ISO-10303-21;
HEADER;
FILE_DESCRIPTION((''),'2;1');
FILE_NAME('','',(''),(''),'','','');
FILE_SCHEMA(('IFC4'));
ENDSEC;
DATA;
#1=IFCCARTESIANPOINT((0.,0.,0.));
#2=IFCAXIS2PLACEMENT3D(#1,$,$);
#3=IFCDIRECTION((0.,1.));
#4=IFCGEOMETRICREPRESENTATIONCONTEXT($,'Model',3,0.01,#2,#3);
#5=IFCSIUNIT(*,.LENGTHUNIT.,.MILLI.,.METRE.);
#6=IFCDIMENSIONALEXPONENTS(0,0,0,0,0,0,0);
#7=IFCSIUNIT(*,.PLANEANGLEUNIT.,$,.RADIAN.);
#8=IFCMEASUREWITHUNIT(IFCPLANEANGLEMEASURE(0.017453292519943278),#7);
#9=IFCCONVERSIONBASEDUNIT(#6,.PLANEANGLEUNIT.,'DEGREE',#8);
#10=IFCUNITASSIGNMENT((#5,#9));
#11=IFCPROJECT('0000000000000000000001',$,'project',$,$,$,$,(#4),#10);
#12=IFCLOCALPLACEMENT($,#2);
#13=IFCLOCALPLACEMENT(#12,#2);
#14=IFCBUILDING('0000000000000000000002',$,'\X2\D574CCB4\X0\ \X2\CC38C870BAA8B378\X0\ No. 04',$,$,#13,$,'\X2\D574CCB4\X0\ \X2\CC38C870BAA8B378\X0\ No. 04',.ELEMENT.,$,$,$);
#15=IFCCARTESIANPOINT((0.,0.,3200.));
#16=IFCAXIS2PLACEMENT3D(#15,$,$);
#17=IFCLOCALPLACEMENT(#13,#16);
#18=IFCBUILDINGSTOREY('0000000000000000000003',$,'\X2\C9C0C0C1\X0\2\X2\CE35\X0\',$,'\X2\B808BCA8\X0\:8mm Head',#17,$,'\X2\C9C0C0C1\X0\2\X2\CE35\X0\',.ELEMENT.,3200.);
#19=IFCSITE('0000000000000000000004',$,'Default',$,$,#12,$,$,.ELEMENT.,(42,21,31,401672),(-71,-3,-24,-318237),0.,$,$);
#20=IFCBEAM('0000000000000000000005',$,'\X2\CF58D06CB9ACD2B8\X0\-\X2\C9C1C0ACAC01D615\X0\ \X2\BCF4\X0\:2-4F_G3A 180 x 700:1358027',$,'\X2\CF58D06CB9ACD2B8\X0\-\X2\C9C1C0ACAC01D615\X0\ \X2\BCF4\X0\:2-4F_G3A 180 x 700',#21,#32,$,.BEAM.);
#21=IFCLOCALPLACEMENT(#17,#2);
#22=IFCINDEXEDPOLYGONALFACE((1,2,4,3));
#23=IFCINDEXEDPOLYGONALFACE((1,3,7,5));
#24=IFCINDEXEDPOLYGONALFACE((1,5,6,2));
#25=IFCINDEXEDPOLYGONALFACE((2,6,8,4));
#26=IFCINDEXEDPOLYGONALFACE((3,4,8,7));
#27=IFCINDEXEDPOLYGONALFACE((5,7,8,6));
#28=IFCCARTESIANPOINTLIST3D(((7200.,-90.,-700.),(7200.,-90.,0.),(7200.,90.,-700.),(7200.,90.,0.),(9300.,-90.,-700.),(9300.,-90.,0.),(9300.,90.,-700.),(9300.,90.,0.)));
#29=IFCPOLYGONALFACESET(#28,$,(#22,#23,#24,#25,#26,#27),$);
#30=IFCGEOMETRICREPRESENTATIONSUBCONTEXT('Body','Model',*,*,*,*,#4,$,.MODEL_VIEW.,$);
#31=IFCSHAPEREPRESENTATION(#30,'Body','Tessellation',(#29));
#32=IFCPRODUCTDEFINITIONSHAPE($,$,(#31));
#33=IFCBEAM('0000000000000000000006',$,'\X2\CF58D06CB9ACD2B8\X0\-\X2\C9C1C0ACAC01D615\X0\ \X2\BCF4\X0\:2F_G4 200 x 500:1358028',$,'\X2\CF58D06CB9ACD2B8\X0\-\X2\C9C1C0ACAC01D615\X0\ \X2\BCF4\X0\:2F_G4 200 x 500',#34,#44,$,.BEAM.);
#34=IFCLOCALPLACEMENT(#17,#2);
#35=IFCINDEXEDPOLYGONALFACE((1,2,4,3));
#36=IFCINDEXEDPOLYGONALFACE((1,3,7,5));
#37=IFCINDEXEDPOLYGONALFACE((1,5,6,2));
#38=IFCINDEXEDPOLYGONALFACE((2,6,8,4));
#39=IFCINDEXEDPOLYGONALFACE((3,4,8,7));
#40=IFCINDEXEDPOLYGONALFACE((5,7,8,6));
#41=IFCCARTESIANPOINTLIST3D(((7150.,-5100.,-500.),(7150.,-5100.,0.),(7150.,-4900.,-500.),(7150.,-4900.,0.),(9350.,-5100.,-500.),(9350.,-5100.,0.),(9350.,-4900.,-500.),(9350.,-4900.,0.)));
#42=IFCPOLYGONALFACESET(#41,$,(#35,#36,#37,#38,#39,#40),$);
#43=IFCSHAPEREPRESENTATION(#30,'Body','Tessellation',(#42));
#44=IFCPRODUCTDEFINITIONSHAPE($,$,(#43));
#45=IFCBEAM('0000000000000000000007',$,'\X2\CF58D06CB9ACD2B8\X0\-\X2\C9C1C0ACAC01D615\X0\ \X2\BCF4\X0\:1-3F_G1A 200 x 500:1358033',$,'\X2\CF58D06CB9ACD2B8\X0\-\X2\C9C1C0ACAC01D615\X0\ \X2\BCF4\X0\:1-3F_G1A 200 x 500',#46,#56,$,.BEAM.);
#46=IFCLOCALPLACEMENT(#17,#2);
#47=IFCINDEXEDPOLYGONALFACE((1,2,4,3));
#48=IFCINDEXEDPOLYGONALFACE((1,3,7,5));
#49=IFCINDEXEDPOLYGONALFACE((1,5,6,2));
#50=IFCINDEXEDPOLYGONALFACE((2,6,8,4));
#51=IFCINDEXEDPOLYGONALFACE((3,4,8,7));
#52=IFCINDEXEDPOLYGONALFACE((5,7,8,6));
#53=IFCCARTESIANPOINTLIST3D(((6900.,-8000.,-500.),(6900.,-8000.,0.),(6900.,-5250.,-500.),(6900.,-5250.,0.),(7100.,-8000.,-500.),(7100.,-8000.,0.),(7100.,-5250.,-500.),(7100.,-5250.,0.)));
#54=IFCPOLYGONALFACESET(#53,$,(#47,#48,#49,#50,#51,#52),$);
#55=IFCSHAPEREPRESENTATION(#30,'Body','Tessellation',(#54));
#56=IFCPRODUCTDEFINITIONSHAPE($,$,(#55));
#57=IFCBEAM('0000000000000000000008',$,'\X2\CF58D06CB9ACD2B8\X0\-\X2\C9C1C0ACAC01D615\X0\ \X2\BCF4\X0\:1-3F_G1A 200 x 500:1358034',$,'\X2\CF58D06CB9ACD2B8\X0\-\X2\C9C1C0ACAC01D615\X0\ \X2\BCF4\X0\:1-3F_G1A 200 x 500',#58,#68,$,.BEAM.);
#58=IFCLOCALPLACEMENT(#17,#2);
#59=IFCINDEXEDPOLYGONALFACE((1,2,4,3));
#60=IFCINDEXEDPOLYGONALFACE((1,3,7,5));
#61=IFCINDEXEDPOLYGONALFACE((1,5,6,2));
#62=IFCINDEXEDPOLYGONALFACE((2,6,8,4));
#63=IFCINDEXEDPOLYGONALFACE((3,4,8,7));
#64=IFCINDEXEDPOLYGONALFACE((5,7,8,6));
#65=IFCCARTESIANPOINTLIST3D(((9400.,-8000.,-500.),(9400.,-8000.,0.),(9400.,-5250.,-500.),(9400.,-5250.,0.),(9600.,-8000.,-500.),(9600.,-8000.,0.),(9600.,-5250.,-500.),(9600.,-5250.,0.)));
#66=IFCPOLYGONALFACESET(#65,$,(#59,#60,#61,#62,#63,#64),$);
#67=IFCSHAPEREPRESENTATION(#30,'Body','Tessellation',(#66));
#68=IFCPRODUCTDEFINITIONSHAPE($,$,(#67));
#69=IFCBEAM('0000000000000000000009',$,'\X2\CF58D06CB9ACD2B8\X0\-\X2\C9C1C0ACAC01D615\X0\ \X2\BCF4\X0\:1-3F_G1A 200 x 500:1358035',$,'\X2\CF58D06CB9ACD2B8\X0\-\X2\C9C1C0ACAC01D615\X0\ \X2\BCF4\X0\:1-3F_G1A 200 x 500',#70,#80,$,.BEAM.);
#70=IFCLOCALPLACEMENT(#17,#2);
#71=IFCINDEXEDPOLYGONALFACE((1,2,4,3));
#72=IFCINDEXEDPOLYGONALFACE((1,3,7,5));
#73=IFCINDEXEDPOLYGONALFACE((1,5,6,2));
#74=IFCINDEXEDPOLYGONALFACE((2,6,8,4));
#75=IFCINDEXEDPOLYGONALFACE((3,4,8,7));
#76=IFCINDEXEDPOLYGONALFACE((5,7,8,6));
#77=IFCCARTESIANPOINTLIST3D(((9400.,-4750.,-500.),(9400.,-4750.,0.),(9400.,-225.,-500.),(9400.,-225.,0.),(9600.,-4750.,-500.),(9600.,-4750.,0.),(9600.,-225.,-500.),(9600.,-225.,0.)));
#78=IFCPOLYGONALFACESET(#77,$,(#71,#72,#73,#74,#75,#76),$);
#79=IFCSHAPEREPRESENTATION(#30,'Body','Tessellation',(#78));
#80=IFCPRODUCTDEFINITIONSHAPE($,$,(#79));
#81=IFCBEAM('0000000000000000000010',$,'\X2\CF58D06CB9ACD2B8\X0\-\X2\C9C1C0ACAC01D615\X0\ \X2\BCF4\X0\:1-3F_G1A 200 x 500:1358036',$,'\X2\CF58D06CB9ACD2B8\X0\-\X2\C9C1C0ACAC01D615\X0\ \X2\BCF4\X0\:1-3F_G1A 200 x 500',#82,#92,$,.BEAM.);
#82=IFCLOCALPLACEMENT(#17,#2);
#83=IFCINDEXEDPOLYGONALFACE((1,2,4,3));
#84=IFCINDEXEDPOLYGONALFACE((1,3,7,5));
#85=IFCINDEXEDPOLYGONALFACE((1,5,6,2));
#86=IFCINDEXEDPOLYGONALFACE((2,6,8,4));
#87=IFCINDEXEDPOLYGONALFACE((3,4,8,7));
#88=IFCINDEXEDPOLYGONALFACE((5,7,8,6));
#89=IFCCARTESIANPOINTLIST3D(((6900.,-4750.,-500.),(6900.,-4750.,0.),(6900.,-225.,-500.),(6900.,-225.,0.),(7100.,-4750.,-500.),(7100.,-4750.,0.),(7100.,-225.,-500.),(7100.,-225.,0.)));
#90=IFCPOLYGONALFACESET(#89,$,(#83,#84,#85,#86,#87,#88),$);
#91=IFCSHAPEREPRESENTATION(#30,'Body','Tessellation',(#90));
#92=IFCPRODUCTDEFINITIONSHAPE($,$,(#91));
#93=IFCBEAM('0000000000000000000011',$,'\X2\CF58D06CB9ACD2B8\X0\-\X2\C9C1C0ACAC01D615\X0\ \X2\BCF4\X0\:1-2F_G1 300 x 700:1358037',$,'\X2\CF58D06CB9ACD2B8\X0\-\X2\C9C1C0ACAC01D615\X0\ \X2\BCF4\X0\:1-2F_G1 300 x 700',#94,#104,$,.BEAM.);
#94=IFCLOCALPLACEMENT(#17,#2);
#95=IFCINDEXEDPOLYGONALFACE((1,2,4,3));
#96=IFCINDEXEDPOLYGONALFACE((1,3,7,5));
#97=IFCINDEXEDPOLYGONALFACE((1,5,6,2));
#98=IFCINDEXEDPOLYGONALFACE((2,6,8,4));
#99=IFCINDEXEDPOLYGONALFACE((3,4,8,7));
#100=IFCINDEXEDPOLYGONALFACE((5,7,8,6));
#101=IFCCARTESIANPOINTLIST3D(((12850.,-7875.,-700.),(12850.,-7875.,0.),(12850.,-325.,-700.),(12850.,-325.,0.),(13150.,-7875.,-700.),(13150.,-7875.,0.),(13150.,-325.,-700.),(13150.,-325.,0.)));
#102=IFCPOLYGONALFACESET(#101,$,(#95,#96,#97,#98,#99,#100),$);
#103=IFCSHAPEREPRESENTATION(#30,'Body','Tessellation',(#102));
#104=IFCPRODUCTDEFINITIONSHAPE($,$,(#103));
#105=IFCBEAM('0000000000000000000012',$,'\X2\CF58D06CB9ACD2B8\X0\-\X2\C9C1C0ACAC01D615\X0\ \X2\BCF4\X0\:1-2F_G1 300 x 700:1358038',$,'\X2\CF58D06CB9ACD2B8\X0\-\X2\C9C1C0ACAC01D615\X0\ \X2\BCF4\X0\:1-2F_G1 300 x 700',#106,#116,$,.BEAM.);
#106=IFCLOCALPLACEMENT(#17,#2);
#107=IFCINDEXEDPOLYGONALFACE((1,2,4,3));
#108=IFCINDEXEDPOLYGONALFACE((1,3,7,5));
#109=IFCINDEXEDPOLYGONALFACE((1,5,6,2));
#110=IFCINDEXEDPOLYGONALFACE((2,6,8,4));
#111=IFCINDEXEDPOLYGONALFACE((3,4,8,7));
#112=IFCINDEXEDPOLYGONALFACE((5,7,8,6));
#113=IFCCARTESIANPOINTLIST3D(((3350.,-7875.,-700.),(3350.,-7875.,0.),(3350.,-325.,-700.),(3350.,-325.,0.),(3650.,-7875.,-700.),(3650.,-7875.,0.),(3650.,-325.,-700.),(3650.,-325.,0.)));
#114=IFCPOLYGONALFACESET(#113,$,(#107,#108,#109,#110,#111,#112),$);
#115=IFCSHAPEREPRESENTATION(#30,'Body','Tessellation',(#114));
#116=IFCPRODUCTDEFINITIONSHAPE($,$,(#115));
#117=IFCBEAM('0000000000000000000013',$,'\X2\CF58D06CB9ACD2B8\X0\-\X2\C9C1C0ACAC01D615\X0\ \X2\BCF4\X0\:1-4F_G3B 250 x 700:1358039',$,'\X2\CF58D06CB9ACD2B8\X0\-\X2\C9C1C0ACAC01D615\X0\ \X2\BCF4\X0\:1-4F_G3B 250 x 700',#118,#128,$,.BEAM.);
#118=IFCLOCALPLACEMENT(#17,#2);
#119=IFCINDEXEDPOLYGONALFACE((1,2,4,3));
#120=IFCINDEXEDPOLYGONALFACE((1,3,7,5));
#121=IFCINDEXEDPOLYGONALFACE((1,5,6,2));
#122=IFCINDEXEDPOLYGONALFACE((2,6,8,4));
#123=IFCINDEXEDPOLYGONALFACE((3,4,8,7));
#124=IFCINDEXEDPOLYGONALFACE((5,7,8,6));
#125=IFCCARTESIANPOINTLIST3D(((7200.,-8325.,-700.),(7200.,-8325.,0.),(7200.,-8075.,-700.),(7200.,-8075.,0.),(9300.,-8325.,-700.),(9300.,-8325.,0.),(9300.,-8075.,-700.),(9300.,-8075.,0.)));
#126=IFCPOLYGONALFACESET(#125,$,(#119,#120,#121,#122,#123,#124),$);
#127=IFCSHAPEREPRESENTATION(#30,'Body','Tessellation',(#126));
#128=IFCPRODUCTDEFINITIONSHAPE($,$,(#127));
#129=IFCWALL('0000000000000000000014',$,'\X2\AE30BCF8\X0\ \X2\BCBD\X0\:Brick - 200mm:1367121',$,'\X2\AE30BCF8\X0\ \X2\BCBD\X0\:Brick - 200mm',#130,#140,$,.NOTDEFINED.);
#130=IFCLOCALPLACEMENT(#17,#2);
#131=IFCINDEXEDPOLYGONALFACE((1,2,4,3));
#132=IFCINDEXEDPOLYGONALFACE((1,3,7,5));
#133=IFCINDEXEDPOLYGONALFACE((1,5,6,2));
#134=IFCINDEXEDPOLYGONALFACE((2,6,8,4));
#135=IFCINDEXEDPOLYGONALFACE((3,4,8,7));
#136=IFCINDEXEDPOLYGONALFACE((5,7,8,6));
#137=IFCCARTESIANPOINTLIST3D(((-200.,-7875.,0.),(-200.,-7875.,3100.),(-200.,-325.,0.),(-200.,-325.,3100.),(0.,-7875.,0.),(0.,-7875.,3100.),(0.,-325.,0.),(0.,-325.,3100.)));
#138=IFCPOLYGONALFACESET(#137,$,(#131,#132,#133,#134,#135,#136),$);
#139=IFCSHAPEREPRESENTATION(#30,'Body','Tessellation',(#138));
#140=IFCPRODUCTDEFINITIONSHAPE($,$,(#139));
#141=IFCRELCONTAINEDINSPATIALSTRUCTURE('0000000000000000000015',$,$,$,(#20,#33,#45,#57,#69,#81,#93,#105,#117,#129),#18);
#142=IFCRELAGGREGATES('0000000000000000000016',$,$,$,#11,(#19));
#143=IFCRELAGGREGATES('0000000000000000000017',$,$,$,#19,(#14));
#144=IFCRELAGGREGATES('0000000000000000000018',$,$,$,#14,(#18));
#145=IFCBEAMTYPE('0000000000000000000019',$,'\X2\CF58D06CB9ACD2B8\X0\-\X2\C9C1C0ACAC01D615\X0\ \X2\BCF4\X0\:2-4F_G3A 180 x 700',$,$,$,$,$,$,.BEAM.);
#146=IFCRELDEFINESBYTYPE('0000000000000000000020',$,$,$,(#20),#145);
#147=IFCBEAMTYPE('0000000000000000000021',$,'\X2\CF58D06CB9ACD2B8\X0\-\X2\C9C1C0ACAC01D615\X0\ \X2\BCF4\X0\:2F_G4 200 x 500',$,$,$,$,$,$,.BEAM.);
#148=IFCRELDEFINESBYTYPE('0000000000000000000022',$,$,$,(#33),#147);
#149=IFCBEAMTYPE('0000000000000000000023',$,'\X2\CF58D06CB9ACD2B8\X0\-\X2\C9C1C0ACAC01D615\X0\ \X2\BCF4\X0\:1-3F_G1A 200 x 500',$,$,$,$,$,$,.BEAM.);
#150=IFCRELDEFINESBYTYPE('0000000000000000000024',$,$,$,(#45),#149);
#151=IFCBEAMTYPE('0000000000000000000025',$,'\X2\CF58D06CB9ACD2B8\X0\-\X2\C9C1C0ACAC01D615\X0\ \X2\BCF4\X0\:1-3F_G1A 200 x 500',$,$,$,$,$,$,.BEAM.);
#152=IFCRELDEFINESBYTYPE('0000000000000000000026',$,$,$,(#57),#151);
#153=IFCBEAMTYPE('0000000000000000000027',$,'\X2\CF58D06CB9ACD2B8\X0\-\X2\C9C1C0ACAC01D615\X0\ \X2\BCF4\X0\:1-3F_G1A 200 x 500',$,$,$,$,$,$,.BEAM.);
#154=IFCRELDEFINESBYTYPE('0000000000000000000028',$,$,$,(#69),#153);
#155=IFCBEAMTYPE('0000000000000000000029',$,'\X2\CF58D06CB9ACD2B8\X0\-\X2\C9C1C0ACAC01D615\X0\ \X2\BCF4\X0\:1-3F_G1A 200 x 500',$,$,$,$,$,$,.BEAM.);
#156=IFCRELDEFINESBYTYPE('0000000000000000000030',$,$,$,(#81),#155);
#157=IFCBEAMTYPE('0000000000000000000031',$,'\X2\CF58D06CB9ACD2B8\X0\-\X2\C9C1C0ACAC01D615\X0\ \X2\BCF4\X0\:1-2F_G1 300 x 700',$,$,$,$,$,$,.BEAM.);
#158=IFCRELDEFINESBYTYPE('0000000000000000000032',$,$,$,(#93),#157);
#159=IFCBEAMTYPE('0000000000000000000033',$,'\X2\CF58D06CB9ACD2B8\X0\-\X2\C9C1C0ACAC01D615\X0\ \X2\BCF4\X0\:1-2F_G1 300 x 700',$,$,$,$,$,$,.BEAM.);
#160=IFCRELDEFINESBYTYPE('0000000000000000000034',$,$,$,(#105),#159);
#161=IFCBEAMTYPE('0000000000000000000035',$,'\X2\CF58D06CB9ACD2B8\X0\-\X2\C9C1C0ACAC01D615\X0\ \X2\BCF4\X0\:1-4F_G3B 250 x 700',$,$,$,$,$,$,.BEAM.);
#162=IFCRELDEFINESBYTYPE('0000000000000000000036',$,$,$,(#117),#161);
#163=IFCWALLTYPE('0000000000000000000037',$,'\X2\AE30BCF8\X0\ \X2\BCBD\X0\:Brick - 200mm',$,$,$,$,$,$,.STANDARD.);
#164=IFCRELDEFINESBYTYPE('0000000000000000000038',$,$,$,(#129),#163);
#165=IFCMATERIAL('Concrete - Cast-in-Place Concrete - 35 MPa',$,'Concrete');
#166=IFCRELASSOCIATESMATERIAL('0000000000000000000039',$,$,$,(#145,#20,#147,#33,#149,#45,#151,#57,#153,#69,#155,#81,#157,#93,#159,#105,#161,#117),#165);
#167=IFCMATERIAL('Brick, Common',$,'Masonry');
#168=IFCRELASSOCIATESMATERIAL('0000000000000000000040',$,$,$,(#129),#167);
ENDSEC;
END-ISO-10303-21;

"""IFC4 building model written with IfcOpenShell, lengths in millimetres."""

from ifc_helpers import new_model, entity, si_unit, converted_unit, direction, frame, origin, place, context, subcontext, project, spatial, indexed_curve, outline, extrude, source, transform, mapped, material, type_object, type_shapes, element, save


model = new_model("IFC4")

# Units and contexts
model_context = context("Model", 3, precision=0.01, world=origin(), true_north=direction((0.0, 1.0)))
body_context = subcontext(model_context, "Body", "Model", "MODEL_VIEW")
ifc_project = project(units=[si_unit("LENGTHUNIT", "METRE", prefix="MILLI"), converted_unit("PLANEANGLEUNIT", "DEGREE", entity("IfcPlaneAngleMeasure", 0.017453292519943278), si_unit("PLANEANGLEUNIT", "RADIAN"), dimensions=[0, 0, 0, 0, 0, 0, 0])], contexts=[model_context])

# Site, building, storey
site_placement = place(None, origin())
site = spatial("IfcSite", under=ifc_project, at=site_placement, Name="Default", CompositionType="ELEMENT", RefLatitude=(42, 21, 31, 401672), RefLongitude=(-71, -3, -24, -318237), RefElevation=0.0)
building_placement = place(site_placement, origin())
building = spatial("IfcBuilding", under=site, at=building_placement, Name="해체 참조모델 No. 04", LongName="해체 참조모델 No. 04", CompositionType="ELEMENT")
storey_placement = place(building_placement, frame((0.0, 0.0, 3200.0)))
storey = spatial("IfcBuildingStorey", under=building, at=storey_placement, Name="지상2층", ObjectType="레벨:8mm Head", LongName="지상2층", CompositionType="ELEMENT", Elevation=3200.0)

# Beams
ifc_material_1 = material(Name="Concrete - Cast-in-Place Concrete - 35 MPa", Category="Concrete")
beam_type_1 = type_object("IfcBeamType", Name="콘크리트-직사각형 보:2-4F_G3A 180 x 700", PredefinedType="BEAM", material=ifc_material_1)
shared_shape_1 = source(origin(), body_context, "Body", "SweptSolid", [
    extrude(outline(indexed_curve([(-350.0, -90.0), (350.0, -90.0), (350.0, 90.0), (-350.0, 90.0), (-350.0, -90.0)], self_intersect=False)), frame((7200.0, 0.0, 2850.0), z_axis=(1.0, 0.0, 0.0), x_axis=(0.0, 0.0, -1.0)), (0.0, 0.0, 1.0), 2100.0),
])
type_shapes(beam_type_1, [shared_shape_1])
beam_1_placement = place(storey_placement, frame((0.0, 0.0, -3200.0)))
element("IfcBeam", 1, at=beam_1_placement, inside=storey, type_object=beam_type_1, material=ifc_material_1, Name="콘크리트-직사각형 보:2-4F_G3A 180 x 700:1358027", ObjectType="콘크리트-직사각형 보:2-4F_G3A 180 x 700", PredefinedType="BEAM", context=body_context, shape_type="MappedRepresentation", body=[
    mapped(shared_shape_1, transform((0.0, 0.0, 0.0), scale=1.0)),
])
beam_type_2 = type_object("IfcBeamType", Name="콘크리트-직사각형 보:2F_G4 200 x 500", PredefinedType="BEAM", material=ifc_material_1)
shared_shape_2 = source(origin(), body_context, "Body", "SweptSolid", [
    extrude(outline(indexed_curve([(-250.0, -100.0), (250.0, -100.0), (250.0, 100.0), (-250.0, 100.0), (-250.0, -100.0)], self_intersect=False)), frame((7150.0, -5000.0, 2950.0), z_axis=(1.0, 0.0, 0.0), x_axis=(0.0, 0.0, -1.0)), (0.0, 0.0, 1.0), 2200.0),
])
type_shapes(beam_type_2, [shared_shape_2])
beam_2_placement = place(storey_placement, frame((0.0, 0.0, -3200.0)))
element("IfcBeam", 2, at=beam_2_placement, inside=storey, type_object=beam_type_2, material=ifc_material_1, Name="콘크리트-직사각형 보:2F_G4 200 x 500:1358028", ObjectType="콘크리트-직사각형 보:2F_G4 200 x 500", PredefinedType="BEAM", context=body_context, shape_type="MappedRepresentation", body=[
    mapped(shared_shape_2, transform((0.0, 0.0, 0.0), scale=1.0)),
])
beam_type_3 = type_object("IfcBeamType", Name="콘크리트-직사각형 보:1-3F_G1A 200 x 500", PredefinedType="BEAM", material=ifc_material_1)
shared_shape_3 = source(origin(), body_context, "Body", "SweptSolid", [
    extrude(outline(indexed_curve([(-100.0, -250.0), (100.0, -250.0), (100.0, 250.0), (-100.0, 250.0), (-100.0, -250.0)], self_intersect=False)), frame((7000.0, -5250.0, 2950.0), z_axis=(0.0, -1.0, 0.0), x_axis=(-1.0, 0.0, 0.0)), (0.0, 0.0, 1.0), 2750.0),
])
type_shapes(beam_type_3, [shared_shape_3])
beam_3_placement = place(storey_placement, frame((0.0, 0.0, -3200.0)))
element("IfcBeam", 3, at=beam_3_placement, inside=storey, type_object=beam_type_3, material=ifc_material_1, Name="콘크리트-직사각형 보:1-3F_G1A 200 x 500:1358033", ObjectType="콘크리트-직사각형 보:1-3F_G1A 200 x 500", PredefinedType="BEAM", context=body_context, shape_type="MappedRepresentation", body=[
    mapped(shared_shape_3, transform((0.0, 0.0, 0.0), scale=1.0)),
])
beam_type_4 = type_object("IfcBeamType", Name="콘크리트-직사각형 보:1-3F_G1A 200 x 500", PredefinedType="BEAM", material=ifc_material_1)
shared_shape_4 = source(origin(), body_context, "Body", "SweptSolid", [
    extrude(outline(indexed_curve([(-100.0, -250.0), (100.0, -250.0), (100.0, 250.0), (-100.0, 250.0), (-100.0, -250.0)], self_intersect=False)), frame((9500.0, -5250.0, 2950.0), z_axis=(0.0, -1.0, 0.0), x_axis=(-1.0, 0.0, 0.0)), (0.0, 0.0, 1.0), 2750.0),
])
type_shapes(beam_type_4, [shared_shape_4])
beam_4_placement = place(storey_placement, frame((0.0, 0.0, -3200.0)))
element("IfcBeam", 4, at=beam_4_placement, inside=storey, type_object=beam_type_4, material=ifc_material_1, Name="콘크리트-직사각형 보:1-3F_G1A 200 x 500:1358034", ObjectType="콘크리트-직사각형 보:1-3F_G1A 200 x 500", PredefinedType="BEAM", context=body_context, shape_type="MappedRepresentation", body=[
    mapped(shared_shape_4, transform((0.0, 0.0, 0.0), scale=1.0)),
])
beam_type_5 = type_object("IfcBeamType", Name="콘크리트-직사각형 보:1-3F_G1A 200 x 500", PredefinedType="BEAM", material=ifc_material_1)
shared_shape_5 = source(origin(), body_context, "Body", "SweptSolid", [
    extrude(outline(indexed_curve([(-100.0, -250.0), (100.0, -250.0), (100.0, 250.0), (-100.0, 250.0), (-100.0, -250.0)], self_intersect=False)), frame((9500.0, -225.0, 2950.0), z_axis=(0.0, -1.0, 0.0), x_axis=(-1.0, 0.0, 0.0)), (0.0, 0.0, 1.0), 4525.0),
])
type_shapes(beam_type_5, [shared_shape_5])
beam_5_placement = place(storey_placement, frame((0.0, 0.0, -3200.0)))
element("IfcBeam", 5, at=beam_5_placement, inside=storey, type_object=beam_type_5, material=ifc_material_1, Name="콘크리트-직사각형 보:1-3F_G1A 200 x 500:1358035", ObjectType="콘크리트-직사각형 보:1-3F_G1A 200 x 500", PredefinedType="BEAM", context=body_context, shape_type="MappedRepresentation", body=[
    mapped(shared_shape_5, transform((0.0, 0.0, 0.0), scale=1.0)),
])
beam_type_6 = type_object("IfcBeamType", Name="콘크리트-직사각형 보:1-3F_G1A 200 x 500", PredefinedType="BEAM", material=ifc_material_1)
shared_shape_6 = source(origin(), body_context, "Body", "SweptSolid", [
    extrude(outline(indexed_curve([(-100.0, -250.0), (100.0, -250.0), (100.0, 250.0), (-100.0, 250.0), (-100.0, -250.0)], self_intersect=False)), frame((7000.0, -225.0, 2950.0), z_axis=(0.0, -1.0, 0.0), x_axis=(-1.0, 0.0, 0.0)), (0.0, 0.0, 1.0), 4525.0),
])
type_shapes(beam_type_6, [shared_shape_6])
beam_6_placement = place(storey_placement, frame((0.0, 0.0, -3200.0)))
element("IfcBeam", 6, at=beam_6_placement, inside=storey, type_object=beam_type_6, material=ifc_material_1, Name="콘크리트-직사각형 보:1-3F_G1A 200 x 500:1358036", ObjectType="콘크리트-직사각형 보:1-3F_G1A 200 x 500", PredefinedType="BEAM", context=body_context, shape_type="MappedRepresentation", body=[
    mapped(shared_shape_6, transform((0.0, 0.0, 0.0), scale=1.0)),
])
beam_type_7 = type_object("IfcBeamType", Name="콘크리트-직사각형 보:1-2F_G1 300 x 700", PredefinedType="BEAM", material=ifc_material_1)
shared_shape_7 = source(origin(), body_context, "Body", "SweptSolid", [
    extrude(outline(indexed_curve([(-150.0, -350.0), (150.0, -350.0), (150.0, 350.0), (-150.0, 350.0), (-150.0, -350.0)], self_intersect=False)), frame((13000.0, -325.0, 2850.0), z_axis=(0.0, -1.0, 0.0), x_axis=(-1.0, 0.0, 0.0)), (0.0, 0.0, 1.0), 7550.0),
])
type_shapes(beam_type_7, [shared_shape_7])
beam_7_placement = place(storey_placement, frame((0.0, 0.0, -3200.0)))
element("IfcBeam", 7, at=beam_7_placement, inside=storey, type_object=beam_type_7, material=ifc_material_1, Name="콘크리트-직사각형 보:1-2F_G1 300 x 700:1358037", ObjectType="콘크리트-직사각형 보:1-2F_G1 300 x 700", PredefinedType="BEAM", context=body_context, shape_type="MappedRepresentation", body=[
    mapped(shared_shape_7, transform((0.0, 0.0, 0.0), scale=1.0)),
])
beam_type_8 = type_object("IfcBeamType", Name="콘크리트-직사각형 보:1-2F_G1 300 x 700", PredefinedType="BEAM", material=ifc_material_1)
shared_shape_8 = source(origin(), body_context, "Body", "SweptSolid", [
    extrude(outline(indexed_curve([(-150.0, -350.0), (150.0, -350.0), (150.0, 350.0), (-150.0, 350.0), (-150.0, -350.0)], self_intersect=False)), frame((3500.0, -325.0, 2850.0), z_axis=(0.0, -1.0, 0.0), x_axis=(-1.0, 0.0, 0.0)), (0.0, 0.0, 1.0), 7550.0),
])
type_shapes(beam_type_8, [shared_shape_8])
beam_8_placement = place(storey_placement, frame((0.0, 0.0, -3200.0)))
element("IfcBeam", 8, at=beam_8_placement, inside=storey, type_object=beam_type_8, material=ifc_material_1, Name="콘크리트-직사각형 보:1-2F_G1 300 x 700:1358038", ObjectType="콘크리트-직사각형 보:1-2F_G1 300 x 700", PredefinedType="BEAM", context=body_context, shape_type="MappedRepresentation", body=[
    mapped(shared_shape_8, transform((0.0, 0.0, 0.0), scale=1.0)),
])
beam_type_9 = type_object("IfcBeamType", Name="콘크리트-직사각형 보:1-4F_G3B 250 x 700", PredefinedType="BEAM", material=ifc_material_1)
shared_shape_9 = source(origin(), body_context, "Body", "SweptSolid", [
    extrude(outline(indexed_curve([(-350.0, -125.0), (350.0, -125.0), (350.0, 125.0), (-350.0, 125.0), (-350.0, -125.0)], self_intersect=False)), frame((7200.0, -8200.0, 2850.0), z_axis=(1.0, 0.0, 0.0), x_axis=(0.0, 0.0, -1.0)), (0.0, 0.0, 1.0), 2100.0),
])
type_shapes(beam_type_9, [shared_shape_9])
beam_9_placement = place(storey_placement, frame((0.0, 0.0, -3200.0)))
element("IfcBeam", 9, at=beam_9_placement, inside=storey, type_object=beam_type_9, material=ifc_material_1, Name="콘크리트-직사각형 보:1-4F_G3B 250 x 700:1358039", ObjectType="콘크리트-직사각형 보:1-4F_G3B 250 x 700", PredefinedType="BEAM", context=body_context, shape_type="MappedRepresentation", body=[
    mapped(shared_shape_9, transform((0.0, 0.0, 0.0), scale=1.0)),
])

# Wall
ifc_material_2 = material(Name="Brick, Common", Category="Masonry")
wall_type = type_object("IfcWallType", Name="기본 벽:Brick - 200mm", PredefinedType="STANDARD")
wall_placement = place(storey_placement, frame((-100.0, -7875.0, 0.0), z_axis=(0.0, 0.0, 1.0), x_axis=(0.0, 1.0, 0.0)))
element("IfcWall", 10, at=wall_placement, inside=storey, type_object=wall_type, material=ifc_material_2, Name="기본 벽:Brick - 200mm:1367121", ObjectType="기본 벽:Brick - 200mm", PredefinedType="NOTDEFINED", context=body_context, shape_type="SweptSolid", body=[
    extrude(outline(indexed_curve([(7550.0, 100.0), (0.0, 100.0), (0.0, -100.0), (7550.0, -100.0), (7550.0, 100.0)], self_intersect=False)), origin(), (0.0, 0.0, 1.0), 3100.0),
])

save(model, "model.ifc")
